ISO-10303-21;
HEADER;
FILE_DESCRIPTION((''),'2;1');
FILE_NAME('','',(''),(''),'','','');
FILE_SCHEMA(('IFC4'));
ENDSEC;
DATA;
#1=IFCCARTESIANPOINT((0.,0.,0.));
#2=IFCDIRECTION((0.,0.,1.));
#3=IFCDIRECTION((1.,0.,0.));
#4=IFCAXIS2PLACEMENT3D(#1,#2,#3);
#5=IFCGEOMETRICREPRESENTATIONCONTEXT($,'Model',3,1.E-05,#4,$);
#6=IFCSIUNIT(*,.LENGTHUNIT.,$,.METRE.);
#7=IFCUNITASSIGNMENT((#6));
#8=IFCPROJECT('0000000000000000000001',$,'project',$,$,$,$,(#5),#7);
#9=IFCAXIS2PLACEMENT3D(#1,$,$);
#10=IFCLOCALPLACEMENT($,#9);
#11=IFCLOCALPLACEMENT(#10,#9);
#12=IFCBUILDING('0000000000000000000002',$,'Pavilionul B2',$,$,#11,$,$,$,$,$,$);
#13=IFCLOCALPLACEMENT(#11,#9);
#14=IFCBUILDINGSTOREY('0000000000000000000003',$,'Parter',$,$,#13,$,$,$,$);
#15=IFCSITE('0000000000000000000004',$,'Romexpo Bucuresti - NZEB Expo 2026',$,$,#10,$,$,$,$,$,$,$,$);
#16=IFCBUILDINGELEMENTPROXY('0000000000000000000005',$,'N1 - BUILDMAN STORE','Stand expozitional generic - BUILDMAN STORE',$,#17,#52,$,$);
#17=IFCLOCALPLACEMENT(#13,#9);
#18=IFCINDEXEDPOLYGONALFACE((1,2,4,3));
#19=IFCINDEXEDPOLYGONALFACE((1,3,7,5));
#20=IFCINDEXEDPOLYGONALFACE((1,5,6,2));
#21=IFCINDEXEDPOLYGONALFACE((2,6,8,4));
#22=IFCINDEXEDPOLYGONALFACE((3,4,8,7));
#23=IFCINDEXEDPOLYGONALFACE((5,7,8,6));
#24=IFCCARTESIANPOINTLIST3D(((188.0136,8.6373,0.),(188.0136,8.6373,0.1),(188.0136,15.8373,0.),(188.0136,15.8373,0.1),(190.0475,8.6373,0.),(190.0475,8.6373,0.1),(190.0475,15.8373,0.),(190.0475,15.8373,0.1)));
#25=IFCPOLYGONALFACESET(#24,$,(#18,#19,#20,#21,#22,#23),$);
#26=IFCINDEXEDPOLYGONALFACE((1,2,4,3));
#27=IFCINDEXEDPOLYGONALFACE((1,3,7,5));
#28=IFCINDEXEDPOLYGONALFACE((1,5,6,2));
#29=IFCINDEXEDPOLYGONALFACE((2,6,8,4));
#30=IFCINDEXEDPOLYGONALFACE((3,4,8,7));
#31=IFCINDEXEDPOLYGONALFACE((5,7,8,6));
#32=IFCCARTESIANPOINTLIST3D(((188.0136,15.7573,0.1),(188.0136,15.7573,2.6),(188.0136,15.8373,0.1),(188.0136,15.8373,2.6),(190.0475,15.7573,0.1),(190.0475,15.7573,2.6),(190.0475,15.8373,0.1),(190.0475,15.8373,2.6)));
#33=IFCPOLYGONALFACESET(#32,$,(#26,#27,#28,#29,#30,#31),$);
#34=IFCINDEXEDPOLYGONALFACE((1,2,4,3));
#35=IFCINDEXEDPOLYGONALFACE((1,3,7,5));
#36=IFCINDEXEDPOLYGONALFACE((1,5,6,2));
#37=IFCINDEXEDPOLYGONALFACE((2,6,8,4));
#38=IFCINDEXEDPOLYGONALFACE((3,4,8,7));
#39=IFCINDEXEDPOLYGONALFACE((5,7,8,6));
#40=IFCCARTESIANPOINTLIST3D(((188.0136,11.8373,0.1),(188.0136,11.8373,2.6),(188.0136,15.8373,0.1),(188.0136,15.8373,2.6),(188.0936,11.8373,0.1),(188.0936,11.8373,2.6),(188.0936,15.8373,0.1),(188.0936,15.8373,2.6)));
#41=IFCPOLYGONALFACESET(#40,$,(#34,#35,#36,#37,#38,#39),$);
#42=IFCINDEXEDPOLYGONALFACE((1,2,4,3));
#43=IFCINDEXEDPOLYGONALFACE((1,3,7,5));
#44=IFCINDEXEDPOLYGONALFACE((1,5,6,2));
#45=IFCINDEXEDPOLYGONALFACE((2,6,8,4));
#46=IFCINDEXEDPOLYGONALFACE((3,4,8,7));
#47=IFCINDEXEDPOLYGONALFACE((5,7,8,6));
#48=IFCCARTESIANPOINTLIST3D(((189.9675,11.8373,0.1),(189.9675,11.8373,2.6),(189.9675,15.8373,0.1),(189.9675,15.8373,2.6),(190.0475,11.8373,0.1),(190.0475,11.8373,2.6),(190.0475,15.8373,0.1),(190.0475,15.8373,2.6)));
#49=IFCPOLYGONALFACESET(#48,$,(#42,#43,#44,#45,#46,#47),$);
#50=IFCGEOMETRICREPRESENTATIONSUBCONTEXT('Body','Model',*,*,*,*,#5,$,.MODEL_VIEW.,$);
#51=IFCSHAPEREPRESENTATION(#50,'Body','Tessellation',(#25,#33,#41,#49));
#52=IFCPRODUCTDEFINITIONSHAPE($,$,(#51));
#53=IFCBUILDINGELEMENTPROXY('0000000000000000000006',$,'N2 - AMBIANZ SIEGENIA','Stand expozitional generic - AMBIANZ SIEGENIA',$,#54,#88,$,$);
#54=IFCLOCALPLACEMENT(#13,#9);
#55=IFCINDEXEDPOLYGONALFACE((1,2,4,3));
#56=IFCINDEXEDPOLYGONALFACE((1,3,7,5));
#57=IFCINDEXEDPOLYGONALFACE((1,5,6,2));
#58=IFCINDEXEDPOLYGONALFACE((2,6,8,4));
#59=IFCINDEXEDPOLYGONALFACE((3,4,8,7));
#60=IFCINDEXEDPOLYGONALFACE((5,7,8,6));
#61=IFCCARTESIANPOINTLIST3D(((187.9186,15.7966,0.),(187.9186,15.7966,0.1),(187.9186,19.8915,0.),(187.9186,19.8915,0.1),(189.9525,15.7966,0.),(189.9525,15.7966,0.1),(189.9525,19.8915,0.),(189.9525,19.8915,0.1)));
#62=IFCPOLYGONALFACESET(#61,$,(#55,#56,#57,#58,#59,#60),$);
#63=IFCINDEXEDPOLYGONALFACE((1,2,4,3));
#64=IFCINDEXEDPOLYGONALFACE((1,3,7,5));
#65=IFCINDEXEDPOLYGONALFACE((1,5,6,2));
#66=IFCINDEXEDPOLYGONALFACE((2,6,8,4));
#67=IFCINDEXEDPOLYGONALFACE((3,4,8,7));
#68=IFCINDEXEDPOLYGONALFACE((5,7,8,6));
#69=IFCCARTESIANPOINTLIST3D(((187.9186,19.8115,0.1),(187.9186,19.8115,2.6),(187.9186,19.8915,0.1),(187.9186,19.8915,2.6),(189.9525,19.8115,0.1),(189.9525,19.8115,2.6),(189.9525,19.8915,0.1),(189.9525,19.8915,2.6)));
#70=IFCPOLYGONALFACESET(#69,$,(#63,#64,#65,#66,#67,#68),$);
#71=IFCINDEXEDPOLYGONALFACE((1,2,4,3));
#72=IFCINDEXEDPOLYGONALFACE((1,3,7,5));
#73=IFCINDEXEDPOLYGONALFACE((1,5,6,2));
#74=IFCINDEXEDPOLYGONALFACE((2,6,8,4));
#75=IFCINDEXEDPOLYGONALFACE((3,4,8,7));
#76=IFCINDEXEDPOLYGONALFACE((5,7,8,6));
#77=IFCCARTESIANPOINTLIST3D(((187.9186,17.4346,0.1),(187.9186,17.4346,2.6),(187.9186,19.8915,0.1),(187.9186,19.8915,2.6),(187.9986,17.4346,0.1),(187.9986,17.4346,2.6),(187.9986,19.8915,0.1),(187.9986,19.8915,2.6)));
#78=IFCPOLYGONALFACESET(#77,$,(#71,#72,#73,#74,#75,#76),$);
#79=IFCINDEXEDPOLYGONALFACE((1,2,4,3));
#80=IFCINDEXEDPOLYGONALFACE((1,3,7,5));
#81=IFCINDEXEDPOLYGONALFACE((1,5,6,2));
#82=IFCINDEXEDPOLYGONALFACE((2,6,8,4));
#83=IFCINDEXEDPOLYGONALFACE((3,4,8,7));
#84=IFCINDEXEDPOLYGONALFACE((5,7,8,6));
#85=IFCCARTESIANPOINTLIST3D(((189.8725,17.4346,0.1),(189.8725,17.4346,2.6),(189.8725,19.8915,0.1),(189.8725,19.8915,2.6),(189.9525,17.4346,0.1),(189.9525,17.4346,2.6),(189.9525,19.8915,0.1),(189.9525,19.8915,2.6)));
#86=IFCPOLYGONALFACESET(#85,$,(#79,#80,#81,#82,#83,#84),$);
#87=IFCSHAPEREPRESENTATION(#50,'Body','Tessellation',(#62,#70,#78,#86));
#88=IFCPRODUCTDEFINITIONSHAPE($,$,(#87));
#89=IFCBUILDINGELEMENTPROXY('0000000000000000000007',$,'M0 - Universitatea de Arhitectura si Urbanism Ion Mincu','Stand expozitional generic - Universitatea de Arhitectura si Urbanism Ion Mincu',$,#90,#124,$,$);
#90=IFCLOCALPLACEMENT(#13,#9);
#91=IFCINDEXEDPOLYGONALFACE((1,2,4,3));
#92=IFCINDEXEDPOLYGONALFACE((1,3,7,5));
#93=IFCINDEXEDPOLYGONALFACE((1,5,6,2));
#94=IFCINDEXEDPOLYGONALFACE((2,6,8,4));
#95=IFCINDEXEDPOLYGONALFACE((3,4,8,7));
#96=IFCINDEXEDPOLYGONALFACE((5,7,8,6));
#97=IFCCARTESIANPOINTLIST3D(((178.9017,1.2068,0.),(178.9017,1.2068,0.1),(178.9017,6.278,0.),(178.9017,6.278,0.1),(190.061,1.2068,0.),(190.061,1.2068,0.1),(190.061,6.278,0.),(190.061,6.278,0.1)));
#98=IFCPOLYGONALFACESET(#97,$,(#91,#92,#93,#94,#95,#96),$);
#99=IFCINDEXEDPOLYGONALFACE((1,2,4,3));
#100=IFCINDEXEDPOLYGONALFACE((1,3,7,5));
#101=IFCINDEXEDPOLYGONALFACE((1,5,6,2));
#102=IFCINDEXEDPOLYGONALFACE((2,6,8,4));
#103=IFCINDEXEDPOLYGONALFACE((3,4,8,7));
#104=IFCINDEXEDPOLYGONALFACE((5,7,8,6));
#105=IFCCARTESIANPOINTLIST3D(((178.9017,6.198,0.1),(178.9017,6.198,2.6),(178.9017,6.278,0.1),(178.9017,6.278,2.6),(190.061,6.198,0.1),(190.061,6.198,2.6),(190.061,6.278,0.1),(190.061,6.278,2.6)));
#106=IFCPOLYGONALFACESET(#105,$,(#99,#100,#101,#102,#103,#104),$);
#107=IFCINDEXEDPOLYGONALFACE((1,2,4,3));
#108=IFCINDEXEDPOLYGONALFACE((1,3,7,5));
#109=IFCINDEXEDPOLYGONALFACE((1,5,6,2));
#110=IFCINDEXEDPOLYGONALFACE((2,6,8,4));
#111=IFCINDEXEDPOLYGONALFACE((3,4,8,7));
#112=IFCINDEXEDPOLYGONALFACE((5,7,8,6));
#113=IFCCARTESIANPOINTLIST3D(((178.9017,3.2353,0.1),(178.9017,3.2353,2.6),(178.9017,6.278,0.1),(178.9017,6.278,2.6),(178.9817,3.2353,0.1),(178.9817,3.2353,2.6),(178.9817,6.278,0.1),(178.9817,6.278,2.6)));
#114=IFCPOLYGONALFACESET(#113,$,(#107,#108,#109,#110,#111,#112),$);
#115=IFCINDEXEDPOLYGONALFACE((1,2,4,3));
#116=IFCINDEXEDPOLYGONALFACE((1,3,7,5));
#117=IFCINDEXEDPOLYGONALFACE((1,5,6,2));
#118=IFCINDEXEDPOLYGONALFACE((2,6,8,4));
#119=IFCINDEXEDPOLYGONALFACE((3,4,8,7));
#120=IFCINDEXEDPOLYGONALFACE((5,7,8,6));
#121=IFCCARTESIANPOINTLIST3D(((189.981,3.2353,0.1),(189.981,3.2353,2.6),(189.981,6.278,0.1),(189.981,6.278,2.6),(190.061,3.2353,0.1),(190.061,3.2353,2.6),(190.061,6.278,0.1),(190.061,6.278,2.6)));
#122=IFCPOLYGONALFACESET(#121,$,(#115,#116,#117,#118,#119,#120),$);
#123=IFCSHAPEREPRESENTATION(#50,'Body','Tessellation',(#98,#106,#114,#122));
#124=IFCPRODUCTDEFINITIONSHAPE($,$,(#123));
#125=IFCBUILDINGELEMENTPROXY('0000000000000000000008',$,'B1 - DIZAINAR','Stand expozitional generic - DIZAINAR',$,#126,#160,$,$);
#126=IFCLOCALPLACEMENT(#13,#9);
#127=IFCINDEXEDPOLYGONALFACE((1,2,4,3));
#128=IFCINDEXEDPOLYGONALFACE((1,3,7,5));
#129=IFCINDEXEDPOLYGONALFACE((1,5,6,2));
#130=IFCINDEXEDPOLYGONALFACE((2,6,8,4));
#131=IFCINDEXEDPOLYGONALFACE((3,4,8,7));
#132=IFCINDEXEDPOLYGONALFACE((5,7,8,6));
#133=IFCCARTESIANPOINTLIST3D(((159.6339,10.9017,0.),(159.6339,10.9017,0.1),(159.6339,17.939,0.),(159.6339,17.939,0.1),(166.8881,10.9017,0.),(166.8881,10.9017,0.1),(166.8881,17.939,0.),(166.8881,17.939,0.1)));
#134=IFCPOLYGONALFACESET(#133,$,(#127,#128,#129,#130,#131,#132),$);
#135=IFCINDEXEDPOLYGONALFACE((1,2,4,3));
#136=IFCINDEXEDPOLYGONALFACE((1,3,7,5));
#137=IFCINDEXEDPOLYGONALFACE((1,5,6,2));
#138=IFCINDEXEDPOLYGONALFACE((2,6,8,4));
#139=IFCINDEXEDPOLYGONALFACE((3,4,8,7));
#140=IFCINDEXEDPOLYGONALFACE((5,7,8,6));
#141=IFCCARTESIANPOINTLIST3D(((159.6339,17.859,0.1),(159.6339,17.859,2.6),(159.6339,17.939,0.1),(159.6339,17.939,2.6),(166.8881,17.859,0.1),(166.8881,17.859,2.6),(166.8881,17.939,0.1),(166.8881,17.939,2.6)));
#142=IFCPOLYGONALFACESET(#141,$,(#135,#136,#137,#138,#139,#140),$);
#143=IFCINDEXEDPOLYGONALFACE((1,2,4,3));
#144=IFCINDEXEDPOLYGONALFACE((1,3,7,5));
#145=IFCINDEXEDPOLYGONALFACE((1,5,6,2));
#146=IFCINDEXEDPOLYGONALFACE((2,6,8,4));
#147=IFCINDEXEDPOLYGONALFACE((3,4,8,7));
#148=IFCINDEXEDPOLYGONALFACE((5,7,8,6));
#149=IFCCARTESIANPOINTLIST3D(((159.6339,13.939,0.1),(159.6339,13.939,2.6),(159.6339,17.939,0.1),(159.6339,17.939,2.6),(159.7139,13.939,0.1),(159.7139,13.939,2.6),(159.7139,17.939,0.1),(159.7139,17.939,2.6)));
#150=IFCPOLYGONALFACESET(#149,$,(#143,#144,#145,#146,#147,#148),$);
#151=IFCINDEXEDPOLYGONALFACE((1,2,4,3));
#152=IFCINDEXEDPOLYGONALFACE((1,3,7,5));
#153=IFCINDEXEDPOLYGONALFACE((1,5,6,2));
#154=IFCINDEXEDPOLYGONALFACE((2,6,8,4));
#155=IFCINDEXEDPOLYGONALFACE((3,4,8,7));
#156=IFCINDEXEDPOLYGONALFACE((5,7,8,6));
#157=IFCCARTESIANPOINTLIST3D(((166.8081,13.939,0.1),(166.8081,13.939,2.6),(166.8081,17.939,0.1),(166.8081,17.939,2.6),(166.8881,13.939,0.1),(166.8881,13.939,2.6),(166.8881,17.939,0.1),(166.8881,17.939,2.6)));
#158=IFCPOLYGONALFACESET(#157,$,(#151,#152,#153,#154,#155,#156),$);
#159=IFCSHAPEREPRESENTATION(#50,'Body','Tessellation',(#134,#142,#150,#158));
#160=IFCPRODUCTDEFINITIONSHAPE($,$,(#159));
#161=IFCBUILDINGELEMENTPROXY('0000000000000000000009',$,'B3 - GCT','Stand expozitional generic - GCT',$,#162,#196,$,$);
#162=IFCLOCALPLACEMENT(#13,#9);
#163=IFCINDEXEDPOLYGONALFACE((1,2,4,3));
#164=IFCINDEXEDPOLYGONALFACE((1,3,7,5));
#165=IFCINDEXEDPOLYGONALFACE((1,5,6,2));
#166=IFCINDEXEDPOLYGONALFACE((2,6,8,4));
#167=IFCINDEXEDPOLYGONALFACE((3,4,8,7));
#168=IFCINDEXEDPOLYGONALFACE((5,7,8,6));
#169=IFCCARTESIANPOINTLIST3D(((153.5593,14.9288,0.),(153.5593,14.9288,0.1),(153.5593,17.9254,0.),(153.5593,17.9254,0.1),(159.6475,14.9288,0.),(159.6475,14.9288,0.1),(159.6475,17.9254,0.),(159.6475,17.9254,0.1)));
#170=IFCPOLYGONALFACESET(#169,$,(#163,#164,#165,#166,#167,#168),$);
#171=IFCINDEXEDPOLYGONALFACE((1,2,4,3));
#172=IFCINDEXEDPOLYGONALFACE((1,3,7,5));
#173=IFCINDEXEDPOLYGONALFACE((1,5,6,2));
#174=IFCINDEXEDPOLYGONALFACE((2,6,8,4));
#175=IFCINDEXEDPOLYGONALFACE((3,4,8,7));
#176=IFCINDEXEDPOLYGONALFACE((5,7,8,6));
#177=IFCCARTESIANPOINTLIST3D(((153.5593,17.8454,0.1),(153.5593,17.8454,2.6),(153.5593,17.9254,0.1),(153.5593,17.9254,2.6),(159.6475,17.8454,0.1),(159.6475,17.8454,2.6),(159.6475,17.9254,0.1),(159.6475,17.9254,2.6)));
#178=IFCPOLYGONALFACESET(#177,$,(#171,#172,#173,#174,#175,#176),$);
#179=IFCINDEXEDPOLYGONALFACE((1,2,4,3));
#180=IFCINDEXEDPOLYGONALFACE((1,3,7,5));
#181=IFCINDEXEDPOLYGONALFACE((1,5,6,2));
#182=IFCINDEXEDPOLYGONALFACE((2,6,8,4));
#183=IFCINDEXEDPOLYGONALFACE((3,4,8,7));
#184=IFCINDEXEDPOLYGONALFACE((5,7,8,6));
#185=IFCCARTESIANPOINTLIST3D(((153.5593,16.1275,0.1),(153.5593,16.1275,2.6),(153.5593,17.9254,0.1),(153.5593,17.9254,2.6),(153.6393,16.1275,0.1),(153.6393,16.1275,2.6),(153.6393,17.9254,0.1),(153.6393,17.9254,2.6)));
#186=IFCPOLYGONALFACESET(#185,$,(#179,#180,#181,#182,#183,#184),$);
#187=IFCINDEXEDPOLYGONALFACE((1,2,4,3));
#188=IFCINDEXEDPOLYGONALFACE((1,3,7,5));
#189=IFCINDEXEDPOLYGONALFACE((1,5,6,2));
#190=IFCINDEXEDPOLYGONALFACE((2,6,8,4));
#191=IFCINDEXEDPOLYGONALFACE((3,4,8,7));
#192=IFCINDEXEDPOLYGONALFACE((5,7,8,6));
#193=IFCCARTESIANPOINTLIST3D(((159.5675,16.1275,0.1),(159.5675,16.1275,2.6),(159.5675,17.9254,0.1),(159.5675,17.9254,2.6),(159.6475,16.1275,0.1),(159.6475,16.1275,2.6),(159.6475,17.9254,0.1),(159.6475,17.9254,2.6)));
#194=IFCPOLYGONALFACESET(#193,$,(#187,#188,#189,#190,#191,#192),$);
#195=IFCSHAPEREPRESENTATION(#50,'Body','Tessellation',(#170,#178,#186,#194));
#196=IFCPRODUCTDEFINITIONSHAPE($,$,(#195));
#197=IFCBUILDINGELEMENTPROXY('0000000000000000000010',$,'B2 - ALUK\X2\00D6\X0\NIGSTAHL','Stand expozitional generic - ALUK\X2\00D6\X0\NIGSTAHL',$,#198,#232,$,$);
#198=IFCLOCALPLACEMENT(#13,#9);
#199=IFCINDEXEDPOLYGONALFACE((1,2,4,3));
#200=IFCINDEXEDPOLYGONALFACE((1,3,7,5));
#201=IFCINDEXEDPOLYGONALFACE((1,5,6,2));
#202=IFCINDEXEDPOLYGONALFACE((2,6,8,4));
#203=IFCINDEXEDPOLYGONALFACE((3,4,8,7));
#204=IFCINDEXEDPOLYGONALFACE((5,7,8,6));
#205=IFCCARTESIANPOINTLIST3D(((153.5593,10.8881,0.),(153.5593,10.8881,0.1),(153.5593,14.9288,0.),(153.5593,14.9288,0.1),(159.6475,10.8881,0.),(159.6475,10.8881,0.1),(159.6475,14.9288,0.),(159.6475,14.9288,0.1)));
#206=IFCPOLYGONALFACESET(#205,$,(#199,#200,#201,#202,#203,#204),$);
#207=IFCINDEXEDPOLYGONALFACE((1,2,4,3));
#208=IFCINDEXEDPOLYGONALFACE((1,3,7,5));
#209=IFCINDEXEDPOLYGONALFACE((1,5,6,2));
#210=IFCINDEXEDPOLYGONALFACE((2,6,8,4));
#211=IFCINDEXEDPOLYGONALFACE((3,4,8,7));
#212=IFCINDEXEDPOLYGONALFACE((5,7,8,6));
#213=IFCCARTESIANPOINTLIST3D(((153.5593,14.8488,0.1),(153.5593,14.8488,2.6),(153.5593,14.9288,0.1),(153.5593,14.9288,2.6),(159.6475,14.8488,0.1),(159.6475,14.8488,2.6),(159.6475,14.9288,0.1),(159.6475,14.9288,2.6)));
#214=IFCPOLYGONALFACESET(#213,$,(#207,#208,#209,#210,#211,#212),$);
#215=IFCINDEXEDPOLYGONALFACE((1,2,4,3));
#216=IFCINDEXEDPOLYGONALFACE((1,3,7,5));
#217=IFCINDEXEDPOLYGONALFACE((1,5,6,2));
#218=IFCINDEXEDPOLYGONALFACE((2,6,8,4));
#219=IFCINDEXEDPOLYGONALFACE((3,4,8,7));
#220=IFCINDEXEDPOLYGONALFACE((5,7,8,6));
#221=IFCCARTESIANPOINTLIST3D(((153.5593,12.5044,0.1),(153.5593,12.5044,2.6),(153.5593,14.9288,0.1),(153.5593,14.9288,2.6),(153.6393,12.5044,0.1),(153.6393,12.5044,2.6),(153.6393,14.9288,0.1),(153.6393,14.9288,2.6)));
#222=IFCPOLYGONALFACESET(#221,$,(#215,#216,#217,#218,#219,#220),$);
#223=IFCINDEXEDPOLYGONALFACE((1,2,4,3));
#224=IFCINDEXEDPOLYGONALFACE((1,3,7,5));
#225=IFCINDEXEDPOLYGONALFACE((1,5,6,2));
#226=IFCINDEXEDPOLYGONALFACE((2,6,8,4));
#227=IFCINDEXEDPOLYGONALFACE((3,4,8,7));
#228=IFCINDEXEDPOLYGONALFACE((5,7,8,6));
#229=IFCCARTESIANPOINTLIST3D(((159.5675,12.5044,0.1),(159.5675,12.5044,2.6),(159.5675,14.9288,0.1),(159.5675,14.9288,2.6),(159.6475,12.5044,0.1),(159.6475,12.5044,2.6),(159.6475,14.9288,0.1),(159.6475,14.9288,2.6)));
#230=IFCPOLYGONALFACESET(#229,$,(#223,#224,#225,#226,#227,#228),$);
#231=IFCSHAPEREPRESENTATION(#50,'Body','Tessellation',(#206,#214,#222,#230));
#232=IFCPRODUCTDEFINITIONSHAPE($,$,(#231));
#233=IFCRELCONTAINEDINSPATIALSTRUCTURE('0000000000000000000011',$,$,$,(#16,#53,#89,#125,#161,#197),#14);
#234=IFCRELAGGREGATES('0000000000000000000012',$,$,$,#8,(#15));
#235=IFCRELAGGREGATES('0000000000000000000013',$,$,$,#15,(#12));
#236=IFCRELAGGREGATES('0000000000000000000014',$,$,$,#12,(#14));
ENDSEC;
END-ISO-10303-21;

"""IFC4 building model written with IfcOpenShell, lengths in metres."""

from ifc_helpers import new_model, si_unit, frame, frame_2d, origin, origin_with_axes, place, context, subcontext, project, spatial, rectangle, extrude, element, save


model = new_model("IFC4")

# Units and contexts
model_context = context("Model", 3, precision=1e-05, world=origin_with_axes())
body_context = subcontext(model_context, "Body", "Model", "MODEL_VIEW")
ifc_project = project(units=[si_unit("LENGTHUNIT", "METRE")], contexts=[model_context])

# Site, building, storey
site_placement = place(None, origin())
site = spatial("IfcSite", under=ifc_project, at=site_placement, Name="Romexpo Bucuresti - NZEB Expo 2026")
building_placement = place(site_placement, origin())
building = spatial("IfcBuilding", under=site, at=building_placement, Name="Pavilionul B2")
storey_placement = place(building_placement, origin())
storey = spatial("IfcBuildingStorey", under=building, at=storey_placement, Name="Parter")

# Building element proxies
proxy_1_placement = place(storey_placement, frame((188.0136, 8.6373, 0.0), z_axis=(0.0, 0.0, 1.0), x_axis=(1.0, 0.0, 0.0)))
element("IfcBuildingElementProxy", 1, at=proxy_1_placement, inside=storey, Name="N1 - BUILDMAN STORE", Description="Stand expozitional generic - BUILDMAN STORE", context=body_context, shape_type="SweptSolid", body=[
    extrude(rectangle(XDim=2.0339, YDim=7.2, at=frame_2d((1.0169, 3.6))), origin(), (0.0, 0.0, 1.0), 0.1),
    extrude(rectangle(XDim=2.0339, YDim=0.08, at=frame_2d((1.0169, 7.16))), frame((0.0, 0.0, 0.1)), (0.0, 0.0, 1.0), 2.5),
    extrude(rectangle(XDim=0.08, YDim=4.0, at=frame_2d((0.04, 5.2))), frame((0.0, 0.0, 0.1)), (0.0, 0.0, 1.0), 2.5),
    extrude(rectangle(XDim=0.08, YDim=4.0, at=frame_2d((1.9939, 5.2))), frame((0.0, 0.0, 0.1)), (0.0, 0.0, 1.0), 2.5),
])
proxy_2_placement = place(storey_placement, frame((187.9186, 15.7966, 0.0), z_axis=(0.0, 0.0, 1.0), x_axis=(1.0, 0.0, 0.0)))
element("IfcBuildingElementProxy", 2, at=proxy_2_placement, inside=storey, Name="N2 - AMBIANZ SIEGENIA", Description="Stand expozitional generic - AMBIANZ SIEGENIA", context=body_context, shape_type="SweptSolid", body=[
    extrude(rectangle(XDim=2.0339, YDim=4.0949, at=frame_2d((1.0169, 2.0475))), origin(), (0.0, 0.0, 1.0), 0.1),
    extrude(rectangle(XDim=2.0339, YDim=0.08, at=frame_2d((1.0169, 4.0549))), frame((0.0, 0.0, 0.1)), (0.0, 0.0, 1.0), 2.5),
    extrude(rectangle(XDim=0.08, YDim=2.4569, at=frame_2d((0.04, 2.8664))), frame((0.0, 0.0, 0.1)), (0.0, 0.0, 1.0), 2.5),
    extrude(rectangle(XDim=0.08, YDim=2.4569, at=frame_2d((1.9939, 2.8664))), frame((0.0, 0.0, 0.1)), (0.0, 0.0, 1.0), 2.5),
])
proxy_3_placement = place(storey_placement, frame((178.9017, 1.2068, 0.0), z_axis=(0.0, 0.0, 1.0), x_axis=(1.0, 0.0, 0.0)))
element("IfcBuildingElementProxy", 3, at=proxy_3_placement, inside=storey, Name="M0 - Universitatea de Arhitectura si Urbanism Ion Mincu", Description="Stand expozitional generic - Universitatea de Arhitectura si Urbanism Ion Mincu", context=body_context, shape_type="SweptSolid", body=[
    extrude(rectangle(XDim=11.1593, YDim=5.0712, at=frame_2d((5.5797, 2.5356))), origin(), (0.0, 0.0, 1.0), 0.1),
    extrude(rectangle(XDim=11.1593, YDim=0.08, at=frame_2d((5.5797, 5.0312))), frame((0.0, 0.0, 0.1)), (0.0, 0.0, 1.0), 2.5),
    extrude(rectangle(XDim=0.08, YDim=3.0427, at=frame_2d((0.04, 3.5498))), frame((0.0, 0.0, 0.1)), (0.0, 0.0, 1.0), 2.5),
    extrude(rectangle(XDim=0.08, YDim=3.0427, at=frame_2d((11.1193, 3.5498))), frame((0.0, 0.0, 0.1)), (0.0, 0.0, 1.0), 2.5),
])
proxy_4_placement = place(storey_placement, frame((159.6339, 10.9017, 0.0), z_axis=(0.0, 0.0, 1.0), x_axis=(1.0, 0.0, 0.0)))
element("IfcBuildingElementProxy", 4, at=proxy_4_placement, inside=storey, Name="B1 - DIZAINAR", Description="Stand expozitional generic - DIZAINAR", context=body_context, shape_type="SweptSolid", body=[
    extrude(rectangle(XDim=7.2542, YDim=7.0373, at=frame_2d((3.6271, 3.5186))), origin(), (0.0, 0.0, 1.0), 0.1),
    extrude(rectangle(XDim=7.2542, YDim=0.08, at=frame_2d((3.6271, 6.9973))), frame((0.0, 0.0, 0.1)), (0.0, 0.0, 1.0), 2.5),
    extrude(rectangle(XDim=0.08, YDim=4.0, at=frame_2d((0.04, 5.0373))), frame((0.0, 0.0, 0.1)), (0.0, 0.0, 1.0), 2.5),
    extrude(rectangle(XDim=0.08, YDim=4.0, at=frame_2d((7.2142, 5.0373))), frame((0.0, 0.0, 0.1)), (0.0, 0.0, 1.0), 2.5),
])
proxy_5_placement = place(storey_placement, frame((153.5593, 14.9288, 0.0), z_axis=(0.0, 0.0, 1.0), x_axis=(1.0, 0.0, 0.0)))
element("IfcBuildingElementProxy", 5, at=proxy_5_placement, inside=storey, Name="B3 - GCT", Description="Stand expozitional generic - GCT", context=body_context, shape_type="SweptSolid", body=[
    extrude(rectangle(XDim=6.0881, YDim=2.9966, at=frame_2d((3.0441, 1.4983))), origin(), (0.0, 0.0, 1.0), 0.1),
    extrude(rectangle(XDim=6.0881, YDim=0.08, at=frame_2d((3.0441, 2.9566))), frame((0.0, 0.0, 0.1)), (0.0, 0.0, 1.0), 2.5),
    extrude(rectangle(XDim=0.08, YDim=1.798, at=frame_2d((0.04, 2.0976))), frame((0.0, 0.0, 0.1)), (0.0, 0.0, 1.0), 2.5),
    extrude(rectangle(XDim=0.08, YDim=1.798, at=frame_2d((6.0481, 2.0976))), frame((0.0, 0.0, 0.1)), (0.0, 0.0, 1.0), 2.5),
])
proxy_6_placement = place(storey_placement, frame((153.5593, 10.8881, 0.0), z_axis=(0.0, 0.0, 1.0), x_axis=(1.0, 0.0, 0.0)))
element("IfcBuildingElementProxy", 6, at=proxy_6_placement, inside=storey, Name="B2 - ALUKÖNIGSTAHL", Description="Stand expozitional generic - ALUKÖNIGSTAHL", context=body_context, shape_type="SweptSolid", body=[
    extrude(rectangle(XDim=6.0881, YDim=4.0407, at=frame_2d((3.0441, 2.0203))), origin(), (0.0, 0.0, 1.0), 0.1),
    extrude(rectangle(XDim=6.0881, YDim=0.08, at=frame_2d((3.0441, 4.0007))), frame((0.0, 0.0, 0.1)), (0.0, 0.0, 1.0), 2.5),
    extrude(rectangle(XDim=0.08, YDim=2.4244, at=frame_2d((0.04, 2.8285))), frame((0.0, 0.0, 0.1)), (0.0, 0.0, 1.0), 2.5),
    extrude(rectangle(XDim=0.08, YDim=2.4244, at=frame_2d((6.0481, 2.8285))), frame((0.0, 0.0, 0.1)), (0.0, 0.0, 1.0), 2.5),
])

save(model, "model.ifc")
